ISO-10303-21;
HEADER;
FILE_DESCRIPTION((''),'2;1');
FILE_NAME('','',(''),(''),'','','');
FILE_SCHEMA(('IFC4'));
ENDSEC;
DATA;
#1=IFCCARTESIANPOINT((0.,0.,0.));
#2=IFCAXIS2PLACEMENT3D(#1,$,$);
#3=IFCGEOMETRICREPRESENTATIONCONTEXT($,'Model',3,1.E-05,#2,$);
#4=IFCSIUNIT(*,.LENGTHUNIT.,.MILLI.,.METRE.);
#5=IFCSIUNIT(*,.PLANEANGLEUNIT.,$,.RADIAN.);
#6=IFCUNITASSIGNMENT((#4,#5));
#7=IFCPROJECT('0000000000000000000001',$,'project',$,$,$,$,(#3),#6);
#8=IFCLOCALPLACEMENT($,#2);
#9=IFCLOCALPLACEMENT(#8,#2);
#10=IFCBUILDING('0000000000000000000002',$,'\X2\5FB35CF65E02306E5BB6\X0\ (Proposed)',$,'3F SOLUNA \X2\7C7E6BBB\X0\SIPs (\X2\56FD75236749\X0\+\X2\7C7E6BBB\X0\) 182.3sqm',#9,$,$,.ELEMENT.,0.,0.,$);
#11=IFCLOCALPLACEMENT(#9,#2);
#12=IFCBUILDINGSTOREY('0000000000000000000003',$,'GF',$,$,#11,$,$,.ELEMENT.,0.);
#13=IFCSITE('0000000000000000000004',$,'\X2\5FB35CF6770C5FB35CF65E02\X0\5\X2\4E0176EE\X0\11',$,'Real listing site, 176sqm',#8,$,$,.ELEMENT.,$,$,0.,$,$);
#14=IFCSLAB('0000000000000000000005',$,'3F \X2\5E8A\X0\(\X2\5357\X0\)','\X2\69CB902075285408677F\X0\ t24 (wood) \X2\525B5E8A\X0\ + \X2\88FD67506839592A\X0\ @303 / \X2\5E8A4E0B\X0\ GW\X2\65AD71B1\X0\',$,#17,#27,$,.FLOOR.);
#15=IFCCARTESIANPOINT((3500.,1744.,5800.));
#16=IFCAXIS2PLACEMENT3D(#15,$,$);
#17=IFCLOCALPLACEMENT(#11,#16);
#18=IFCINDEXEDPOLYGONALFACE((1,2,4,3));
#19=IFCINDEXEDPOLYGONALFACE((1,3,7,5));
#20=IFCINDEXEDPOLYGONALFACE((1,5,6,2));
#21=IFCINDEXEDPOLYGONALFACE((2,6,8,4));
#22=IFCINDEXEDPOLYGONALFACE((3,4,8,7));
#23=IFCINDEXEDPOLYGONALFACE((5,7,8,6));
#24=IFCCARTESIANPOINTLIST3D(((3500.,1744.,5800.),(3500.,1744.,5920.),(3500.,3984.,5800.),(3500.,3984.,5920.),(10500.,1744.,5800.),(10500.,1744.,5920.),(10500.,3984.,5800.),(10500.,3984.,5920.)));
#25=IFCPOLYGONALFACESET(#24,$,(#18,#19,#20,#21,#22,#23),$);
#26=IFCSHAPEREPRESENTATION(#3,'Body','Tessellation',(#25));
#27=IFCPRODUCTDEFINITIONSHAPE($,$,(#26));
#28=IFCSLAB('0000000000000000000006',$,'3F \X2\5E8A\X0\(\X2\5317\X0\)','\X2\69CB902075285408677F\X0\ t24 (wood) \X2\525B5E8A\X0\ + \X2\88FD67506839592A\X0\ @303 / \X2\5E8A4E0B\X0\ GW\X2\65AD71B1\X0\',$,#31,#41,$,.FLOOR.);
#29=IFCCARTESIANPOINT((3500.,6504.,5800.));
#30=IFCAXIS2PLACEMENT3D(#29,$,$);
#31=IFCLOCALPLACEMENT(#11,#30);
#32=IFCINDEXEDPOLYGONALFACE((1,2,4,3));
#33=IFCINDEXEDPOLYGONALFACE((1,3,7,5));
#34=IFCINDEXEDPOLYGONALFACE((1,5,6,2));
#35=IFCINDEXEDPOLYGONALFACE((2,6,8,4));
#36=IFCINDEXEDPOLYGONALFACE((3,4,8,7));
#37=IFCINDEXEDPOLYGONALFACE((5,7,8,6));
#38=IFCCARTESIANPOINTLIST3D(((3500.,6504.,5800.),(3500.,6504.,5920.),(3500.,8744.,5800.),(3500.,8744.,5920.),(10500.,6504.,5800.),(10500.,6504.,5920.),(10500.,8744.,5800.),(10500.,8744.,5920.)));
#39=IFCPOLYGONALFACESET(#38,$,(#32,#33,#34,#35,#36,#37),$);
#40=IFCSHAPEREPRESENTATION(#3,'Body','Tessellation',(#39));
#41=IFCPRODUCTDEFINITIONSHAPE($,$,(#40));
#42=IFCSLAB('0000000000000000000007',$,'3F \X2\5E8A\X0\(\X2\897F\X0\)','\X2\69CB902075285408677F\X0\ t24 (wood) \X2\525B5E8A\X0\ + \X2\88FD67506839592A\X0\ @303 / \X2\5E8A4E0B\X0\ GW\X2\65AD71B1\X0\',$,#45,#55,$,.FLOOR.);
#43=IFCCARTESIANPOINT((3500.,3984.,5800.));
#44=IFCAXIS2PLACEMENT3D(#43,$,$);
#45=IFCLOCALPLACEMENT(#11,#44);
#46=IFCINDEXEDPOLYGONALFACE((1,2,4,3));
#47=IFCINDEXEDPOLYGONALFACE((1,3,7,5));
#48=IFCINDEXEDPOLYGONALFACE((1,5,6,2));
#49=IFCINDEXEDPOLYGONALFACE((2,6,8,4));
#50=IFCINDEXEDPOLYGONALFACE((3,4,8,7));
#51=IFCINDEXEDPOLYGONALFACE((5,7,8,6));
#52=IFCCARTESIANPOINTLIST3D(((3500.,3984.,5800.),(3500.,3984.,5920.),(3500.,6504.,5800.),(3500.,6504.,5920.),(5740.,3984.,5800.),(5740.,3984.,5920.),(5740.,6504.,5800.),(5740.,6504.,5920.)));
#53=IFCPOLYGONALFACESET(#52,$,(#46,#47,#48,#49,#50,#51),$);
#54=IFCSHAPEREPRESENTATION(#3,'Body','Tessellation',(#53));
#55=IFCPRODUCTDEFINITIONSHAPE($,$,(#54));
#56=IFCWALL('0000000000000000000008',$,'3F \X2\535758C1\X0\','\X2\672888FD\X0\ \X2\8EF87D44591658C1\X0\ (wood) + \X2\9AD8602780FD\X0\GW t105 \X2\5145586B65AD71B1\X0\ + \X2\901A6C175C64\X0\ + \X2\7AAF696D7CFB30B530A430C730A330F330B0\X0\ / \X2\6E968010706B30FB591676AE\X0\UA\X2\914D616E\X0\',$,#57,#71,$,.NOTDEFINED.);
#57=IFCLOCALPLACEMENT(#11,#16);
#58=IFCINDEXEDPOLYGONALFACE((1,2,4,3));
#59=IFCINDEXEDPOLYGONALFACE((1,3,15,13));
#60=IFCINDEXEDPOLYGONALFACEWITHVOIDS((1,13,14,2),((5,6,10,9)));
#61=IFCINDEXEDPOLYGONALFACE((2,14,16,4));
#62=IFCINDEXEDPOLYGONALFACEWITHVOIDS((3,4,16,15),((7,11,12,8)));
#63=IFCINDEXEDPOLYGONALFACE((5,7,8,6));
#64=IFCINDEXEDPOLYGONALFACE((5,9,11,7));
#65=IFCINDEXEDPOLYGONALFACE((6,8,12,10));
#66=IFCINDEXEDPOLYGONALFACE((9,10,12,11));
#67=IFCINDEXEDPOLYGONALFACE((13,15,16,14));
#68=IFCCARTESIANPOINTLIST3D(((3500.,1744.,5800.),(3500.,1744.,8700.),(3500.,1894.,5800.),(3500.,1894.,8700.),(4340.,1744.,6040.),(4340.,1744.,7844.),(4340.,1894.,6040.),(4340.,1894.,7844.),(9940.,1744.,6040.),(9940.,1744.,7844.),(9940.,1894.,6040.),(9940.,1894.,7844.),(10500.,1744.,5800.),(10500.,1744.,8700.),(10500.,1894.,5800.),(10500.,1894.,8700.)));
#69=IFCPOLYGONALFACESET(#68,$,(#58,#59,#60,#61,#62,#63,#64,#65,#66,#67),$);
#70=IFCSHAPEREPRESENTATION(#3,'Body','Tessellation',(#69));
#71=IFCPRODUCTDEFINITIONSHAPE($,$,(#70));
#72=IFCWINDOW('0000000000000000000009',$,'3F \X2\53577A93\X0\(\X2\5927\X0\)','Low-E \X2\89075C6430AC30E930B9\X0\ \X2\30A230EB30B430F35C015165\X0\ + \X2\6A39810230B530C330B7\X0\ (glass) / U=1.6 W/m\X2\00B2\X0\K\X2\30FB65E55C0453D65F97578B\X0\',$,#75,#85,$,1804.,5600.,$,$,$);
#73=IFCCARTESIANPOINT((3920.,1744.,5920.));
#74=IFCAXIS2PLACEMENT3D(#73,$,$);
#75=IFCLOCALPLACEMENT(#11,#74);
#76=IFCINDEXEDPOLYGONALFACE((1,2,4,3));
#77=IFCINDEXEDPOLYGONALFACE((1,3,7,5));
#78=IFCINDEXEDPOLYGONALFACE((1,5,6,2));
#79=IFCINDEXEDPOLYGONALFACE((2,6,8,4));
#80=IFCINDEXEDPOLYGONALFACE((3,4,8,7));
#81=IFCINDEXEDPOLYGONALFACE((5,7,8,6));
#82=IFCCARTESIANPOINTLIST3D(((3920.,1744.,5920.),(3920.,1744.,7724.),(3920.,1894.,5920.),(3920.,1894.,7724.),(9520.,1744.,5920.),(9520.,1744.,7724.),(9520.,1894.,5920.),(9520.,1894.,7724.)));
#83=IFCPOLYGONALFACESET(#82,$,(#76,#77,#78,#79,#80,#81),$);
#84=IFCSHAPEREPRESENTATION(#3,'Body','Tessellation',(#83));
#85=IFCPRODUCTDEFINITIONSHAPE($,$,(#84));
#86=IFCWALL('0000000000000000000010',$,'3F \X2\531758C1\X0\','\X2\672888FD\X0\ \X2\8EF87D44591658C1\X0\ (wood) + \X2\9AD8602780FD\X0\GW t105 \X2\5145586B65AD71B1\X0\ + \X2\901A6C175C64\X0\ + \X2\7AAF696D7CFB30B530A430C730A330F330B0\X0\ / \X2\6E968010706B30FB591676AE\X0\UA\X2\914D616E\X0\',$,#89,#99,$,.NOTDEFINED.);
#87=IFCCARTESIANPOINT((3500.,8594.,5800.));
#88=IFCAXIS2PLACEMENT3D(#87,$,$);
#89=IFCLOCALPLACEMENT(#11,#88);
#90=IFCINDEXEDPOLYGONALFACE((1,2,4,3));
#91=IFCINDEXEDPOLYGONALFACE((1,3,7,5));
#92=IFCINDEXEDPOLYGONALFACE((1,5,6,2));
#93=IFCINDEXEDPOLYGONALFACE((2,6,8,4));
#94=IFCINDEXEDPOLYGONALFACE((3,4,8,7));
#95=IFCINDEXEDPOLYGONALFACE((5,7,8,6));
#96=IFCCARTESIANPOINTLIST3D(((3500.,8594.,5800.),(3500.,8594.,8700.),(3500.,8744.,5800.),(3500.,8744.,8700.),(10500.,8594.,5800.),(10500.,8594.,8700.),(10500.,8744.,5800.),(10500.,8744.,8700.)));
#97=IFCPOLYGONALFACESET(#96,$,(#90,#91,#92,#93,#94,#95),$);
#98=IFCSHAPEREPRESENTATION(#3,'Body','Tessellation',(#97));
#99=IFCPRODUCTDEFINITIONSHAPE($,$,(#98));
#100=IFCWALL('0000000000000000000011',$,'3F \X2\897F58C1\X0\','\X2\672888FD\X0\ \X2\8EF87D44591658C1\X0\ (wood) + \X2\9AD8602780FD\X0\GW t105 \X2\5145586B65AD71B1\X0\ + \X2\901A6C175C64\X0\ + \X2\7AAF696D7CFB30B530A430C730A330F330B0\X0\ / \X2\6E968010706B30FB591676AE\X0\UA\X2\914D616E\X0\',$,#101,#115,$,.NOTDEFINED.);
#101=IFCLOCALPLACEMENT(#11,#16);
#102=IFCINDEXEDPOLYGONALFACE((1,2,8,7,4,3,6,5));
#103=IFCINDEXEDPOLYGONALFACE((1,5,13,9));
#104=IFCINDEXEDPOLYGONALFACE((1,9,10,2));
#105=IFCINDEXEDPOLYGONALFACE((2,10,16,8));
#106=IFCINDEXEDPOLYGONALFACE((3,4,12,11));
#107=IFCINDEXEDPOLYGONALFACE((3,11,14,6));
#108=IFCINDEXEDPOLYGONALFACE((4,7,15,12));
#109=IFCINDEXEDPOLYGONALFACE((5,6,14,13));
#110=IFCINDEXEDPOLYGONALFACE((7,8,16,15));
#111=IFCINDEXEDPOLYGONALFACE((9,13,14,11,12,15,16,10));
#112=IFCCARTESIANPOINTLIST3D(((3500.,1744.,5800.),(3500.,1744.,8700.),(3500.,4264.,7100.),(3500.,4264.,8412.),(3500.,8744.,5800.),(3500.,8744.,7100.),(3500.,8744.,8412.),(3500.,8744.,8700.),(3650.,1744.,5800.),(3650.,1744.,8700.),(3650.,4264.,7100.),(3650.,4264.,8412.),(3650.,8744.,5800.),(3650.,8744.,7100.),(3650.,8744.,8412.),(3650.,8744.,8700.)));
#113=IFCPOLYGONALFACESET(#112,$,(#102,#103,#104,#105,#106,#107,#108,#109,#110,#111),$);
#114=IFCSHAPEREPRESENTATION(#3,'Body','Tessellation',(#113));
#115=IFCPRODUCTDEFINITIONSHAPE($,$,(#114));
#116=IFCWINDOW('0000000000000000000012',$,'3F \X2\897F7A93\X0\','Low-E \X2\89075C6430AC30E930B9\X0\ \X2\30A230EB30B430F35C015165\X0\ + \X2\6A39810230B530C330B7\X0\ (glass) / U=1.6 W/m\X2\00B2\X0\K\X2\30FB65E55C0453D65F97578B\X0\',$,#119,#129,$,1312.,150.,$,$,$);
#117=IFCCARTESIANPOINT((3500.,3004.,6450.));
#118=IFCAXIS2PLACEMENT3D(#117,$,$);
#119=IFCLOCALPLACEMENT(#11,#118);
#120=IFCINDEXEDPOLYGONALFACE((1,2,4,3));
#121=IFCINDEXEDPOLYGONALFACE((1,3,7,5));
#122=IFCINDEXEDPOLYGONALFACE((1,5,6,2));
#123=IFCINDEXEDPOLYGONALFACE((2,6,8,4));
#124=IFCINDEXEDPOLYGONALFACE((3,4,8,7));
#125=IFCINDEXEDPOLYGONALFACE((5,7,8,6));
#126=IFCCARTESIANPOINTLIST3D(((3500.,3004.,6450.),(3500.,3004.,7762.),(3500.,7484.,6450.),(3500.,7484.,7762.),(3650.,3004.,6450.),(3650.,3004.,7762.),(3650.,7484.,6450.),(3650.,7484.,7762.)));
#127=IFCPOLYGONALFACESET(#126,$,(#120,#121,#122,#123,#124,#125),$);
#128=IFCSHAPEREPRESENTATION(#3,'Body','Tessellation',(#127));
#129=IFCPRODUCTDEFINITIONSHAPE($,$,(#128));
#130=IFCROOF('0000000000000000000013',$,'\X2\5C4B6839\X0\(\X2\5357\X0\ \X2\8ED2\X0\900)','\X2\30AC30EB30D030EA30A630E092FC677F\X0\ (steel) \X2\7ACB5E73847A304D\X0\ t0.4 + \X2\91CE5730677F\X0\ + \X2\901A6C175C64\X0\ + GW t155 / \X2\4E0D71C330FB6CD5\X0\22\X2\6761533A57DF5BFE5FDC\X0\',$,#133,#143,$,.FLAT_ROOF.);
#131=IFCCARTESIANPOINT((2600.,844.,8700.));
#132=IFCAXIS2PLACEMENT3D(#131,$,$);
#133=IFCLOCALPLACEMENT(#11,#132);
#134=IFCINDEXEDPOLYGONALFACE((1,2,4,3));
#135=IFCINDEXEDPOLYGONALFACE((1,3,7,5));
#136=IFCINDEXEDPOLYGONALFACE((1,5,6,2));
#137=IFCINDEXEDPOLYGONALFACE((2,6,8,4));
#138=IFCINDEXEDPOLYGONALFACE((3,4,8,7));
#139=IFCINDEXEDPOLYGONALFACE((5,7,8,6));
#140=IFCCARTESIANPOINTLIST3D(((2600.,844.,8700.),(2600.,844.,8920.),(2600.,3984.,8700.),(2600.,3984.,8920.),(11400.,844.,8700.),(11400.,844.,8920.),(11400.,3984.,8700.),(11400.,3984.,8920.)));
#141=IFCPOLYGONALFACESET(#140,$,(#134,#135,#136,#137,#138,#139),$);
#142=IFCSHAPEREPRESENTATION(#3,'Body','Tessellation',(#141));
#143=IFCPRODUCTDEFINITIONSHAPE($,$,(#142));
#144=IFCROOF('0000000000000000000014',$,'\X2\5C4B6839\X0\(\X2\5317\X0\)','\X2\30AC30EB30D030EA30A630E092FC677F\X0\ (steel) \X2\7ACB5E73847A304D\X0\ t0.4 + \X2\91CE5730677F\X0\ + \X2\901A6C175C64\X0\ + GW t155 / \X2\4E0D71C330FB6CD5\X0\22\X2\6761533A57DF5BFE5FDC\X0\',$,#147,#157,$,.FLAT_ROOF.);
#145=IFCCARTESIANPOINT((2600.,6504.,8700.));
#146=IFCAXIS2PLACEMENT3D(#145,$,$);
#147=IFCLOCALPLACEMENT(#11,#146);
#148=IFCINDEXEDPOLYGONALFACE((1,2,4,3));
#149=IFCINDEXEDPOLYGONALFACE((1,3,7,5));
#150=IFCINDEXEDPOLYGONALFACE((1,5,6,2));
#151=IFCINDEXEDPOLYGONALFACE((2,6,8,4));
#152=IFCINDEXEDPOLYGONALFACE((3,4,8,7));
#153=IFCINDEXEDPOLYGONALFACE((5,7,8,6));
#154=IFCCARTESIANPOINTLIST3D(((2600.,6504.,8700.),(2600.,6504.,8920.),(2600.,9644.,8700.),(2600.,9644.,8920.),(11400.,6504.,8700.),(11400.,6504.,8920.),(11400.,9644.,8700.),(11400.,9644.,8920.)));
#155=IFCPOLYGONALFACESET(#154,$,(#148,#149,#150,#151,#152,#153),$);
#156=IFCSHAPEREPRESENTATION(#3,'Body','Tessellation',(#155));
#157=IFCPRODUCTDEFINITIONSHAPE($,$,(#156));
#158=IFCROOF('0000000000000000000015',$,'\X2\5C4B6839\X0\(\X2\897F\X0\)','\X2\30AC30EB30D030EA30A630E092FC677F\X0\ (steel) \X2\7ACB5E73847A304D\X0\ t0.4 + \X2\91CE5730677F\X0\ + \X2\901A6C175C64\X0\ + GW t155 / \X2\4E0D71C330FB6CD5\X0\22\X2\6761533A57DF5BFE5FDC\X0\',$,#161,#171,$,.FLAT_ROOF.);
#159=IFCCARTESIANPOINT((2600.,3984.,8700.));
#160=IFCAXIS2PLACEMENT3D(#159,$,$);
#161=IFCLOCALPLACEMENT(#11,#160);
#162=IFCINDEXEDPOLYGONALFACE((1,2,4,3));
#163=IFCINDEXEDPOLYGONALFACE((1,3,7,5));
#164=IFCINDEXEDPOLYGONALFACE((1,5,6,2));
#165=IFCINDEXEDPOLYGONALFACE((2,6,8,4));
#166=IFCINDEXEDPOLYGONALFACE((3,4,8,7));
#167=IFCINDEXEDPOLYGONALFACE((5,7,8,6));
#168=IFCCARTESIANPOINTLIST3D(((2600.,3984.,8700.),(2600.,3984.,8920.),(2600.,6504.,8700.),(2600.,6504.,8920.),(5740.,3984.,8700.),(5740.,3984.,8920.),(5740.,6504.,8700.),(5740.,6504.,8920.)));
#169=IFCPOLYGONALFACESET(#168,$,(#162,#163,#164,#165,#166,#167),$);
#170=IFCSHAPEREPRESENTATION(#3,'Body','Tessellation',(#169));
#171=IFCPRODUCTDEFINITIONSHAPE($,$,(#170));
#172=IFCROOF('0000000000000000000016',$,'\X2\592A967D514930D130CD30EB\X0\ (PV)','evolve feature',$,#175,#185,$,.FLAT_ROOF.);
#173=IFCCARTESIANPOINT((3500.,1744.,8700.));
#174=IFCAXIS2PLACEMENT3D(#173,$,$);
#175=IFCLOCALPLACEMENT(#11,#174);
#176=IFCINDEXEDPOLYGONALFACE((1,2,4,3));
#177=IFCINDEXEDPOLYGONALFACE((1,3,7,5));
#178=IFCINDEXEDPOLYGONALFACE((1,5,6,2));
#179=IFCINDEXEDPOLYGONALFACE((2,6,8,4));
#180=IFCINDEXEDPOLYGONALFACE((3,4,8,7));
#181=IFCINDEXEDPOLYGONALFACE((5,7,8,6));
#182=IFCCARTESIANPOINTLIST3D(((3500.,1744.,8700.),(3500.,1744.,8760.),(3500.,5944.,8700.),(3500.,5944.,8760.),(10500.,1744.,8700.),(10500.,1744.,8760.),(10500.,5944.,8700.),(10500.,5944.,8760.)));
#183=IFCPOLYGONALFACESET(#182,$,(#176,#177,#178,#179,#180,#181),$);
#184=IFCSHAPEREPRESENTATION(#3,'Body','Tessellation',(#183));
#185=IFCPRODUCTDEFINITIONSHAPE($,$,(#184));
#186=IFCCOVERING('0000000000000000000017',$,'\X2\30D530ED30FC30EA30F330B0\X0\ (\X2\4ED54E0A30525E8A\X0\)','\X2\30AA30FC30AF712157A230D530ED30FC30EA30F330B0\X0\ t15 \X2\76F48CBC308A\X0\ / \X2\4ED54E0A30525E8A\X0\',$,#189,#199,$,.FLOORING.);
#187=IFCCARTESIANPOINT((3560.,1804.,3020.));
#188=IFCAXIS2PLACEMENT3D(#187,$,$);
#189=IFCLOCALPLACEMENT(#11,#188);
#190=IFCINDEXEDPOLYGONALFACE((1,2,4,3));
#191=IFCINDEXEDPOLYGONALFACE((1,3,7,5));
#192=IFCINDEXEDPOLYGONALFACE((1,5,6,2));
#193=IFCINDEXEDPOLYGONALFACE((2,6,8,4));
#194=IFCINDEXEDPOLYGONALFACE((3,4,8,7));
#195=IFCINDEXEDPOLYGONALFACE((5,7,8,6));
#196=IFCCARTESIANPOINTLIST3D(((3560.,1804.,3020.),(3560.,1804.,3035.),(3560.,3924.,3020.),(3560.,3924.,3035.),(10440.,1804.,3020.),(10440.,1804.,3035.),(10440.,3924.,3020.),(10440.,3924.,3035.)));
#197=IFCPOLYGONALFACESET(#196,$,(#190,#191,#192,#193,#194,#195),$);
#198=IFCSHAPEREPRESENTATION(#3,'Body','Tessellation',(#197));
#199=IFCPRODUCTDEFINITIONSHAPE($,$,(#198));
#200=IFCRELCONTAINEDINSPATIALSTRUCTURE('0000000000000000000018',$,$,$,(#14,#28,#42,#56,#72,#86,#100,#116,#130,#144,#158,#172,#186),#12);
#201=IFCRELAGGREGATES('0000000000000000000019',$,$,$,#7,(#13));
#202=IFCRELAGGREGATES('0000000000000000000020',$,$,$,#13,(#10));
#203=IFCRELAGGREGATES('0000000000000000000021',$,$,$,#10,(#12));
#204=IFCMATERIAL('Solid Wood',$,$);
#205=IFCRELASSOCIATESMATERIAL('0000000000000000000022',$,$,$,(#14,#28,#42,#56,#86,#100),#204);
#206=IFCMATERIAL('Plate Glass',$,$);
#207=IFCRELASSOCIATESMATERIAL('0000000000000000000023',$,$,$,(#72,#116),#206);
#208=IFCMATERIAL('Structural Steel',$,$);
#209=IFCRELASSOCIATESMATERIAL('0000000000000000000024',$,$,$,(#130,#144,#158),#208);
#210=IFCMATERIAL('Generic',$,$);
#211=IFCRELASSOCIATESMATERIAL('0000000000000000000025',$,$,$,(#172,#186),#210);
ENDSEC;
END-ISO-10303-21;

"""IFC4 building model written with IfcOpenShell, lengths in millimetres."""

from ifc_helpers import new_model, si_unit, frame, frame_2d, origin, place, context, project, spatial, rectangle, extrude, material, element, fill, save


model = new_model("IFC4")

# Units and contexts
model_context = context("Model", 3, precision=1e-05, world=origin())
ifc_project = project(units=[si_unit("LENGTHUNIT", "METRE", prefix="MILLI"), si_unit("PLANEANGLEUNIT", "RADIAN")], contexts=[model_context])

# Site, building, storey
site_placement = place(None, origin())
site = spatial("IfcSite", under=ifc_project, at=site_placement, Name="徳島県徳島市5丁目11", ObjectType="Real listing site, 176sqm", CompositionType="ELEMENT", RefElevation=0.0)
building_placement = place(site_placement, origin())
building = spatial("IfcBuilding", under=site, at=building_placement, Name="徳島市の家 (Proposed)", ObjectType="3F SOLUNA 籾殻SIPs (国産杉+籾殻) 182.3sqm", CompositionType="ELEMENT", ElevationOfRefHeight=0.0, ElevationOfTerrain=0.0)
storey_placement = place(building_placement, origin())
storey = spatial("IfcBuildingStorey", under=building, at=storey_placement, Name="GF", CompositionType="ELEMENT", Elevation=0.0)

# Slabs
ifc_material_1 = material(Name="Solid Wood")
slab_1_placement = place(storey_placement, frame((3500.0, 1744.0, 5800.0)))
element("IfcSlab", 1, at=slab_1_placement, inside=storey, material=ifc_material_1, Name="3F 床(南)", Description="構造用合板 t24 (wood) 剛床 + 製材根太 @303 / 床下 GW断熱", PredefinedType="FLOOR", context=model_context, shape_type="SweptSolid", body=[
    extrude(rectangle(XDim=7000.0, YDim=2240.0, at=frame_2d((3500.0, 1120.0))), frame((3500.0, 1744.0, 5800.0)), (0.0, 0.0, 1.0), 120.0),
])
slab_2_placement = place(storey_placement, frame((3500.0, 6504.0, 5800.0)))
element("IfcSlab", 2, at=slab_2_placement, inside=storey, material=ifc_material_1, Name="3F 床(北)", Description="構造用合板 t24 (wood) 剛床 + 製材根太 @303 / 床下 GW断熱", PredefinedType="FLOOR", context=model_context, shape_type="SweptSolid", body=[
    extrude(rectangle(XDim=7000.0, YDim=2240.0, at=frame_2d((3500.0, 1120.0))), frame((3500.0, 6504.0, 5800.0)), (0.0, 0.0, 1.0), 120.0),
])
slab_3_placement = place(storey_placement, frame((3500.0, 3984.0, 5800.0)))
element("IfcSlab", 3, at=slab_3_placement, inside=storey, material=ifc_material_1, Name="3F 床(西)", Description="構造用合板 t24 (wood) 剛床 + 製材根太 @303 / 床下 GW断熱", PredefinedType="FLOOR", context=model_context, shape_type="SweptSolid", body=[
    extrude(rectangle(XDim=2240.0, YDim=2520.0, at=frame_2d((1120.0, 1260.0))), frame((3500.0, 3984.0, 5800.0)), (0.0, 0.0, 1.0), 120.0),
])

# Wall, opening, window
wall_1_placement = place(storey_placement, frame((3500.0, 1744.0, 5800.0)))
wall_1 = element("IfcWall", 4, at=wall_1_placement, inside=storey, material=ifc_material_1, Name="3F 南壁", Description="木製 軸組外壁 (wood) + 高性能GW t105 充填断熱 + 通気層 + 窯業系サイディング / 準耐火・外皮UA配慮", PredefinedType="NOTDEFINED", context=model_context, shape_type="SweptSolid", body=[
    extrude(rectangle(XDim=7000.0, YDim=150.0, at=frame_2d((3500.0, 75.0))), frame((3500.0, 1744.0, 5800.0)), (0.0, 0.0, 1.0), 2900.0),
])
opening_1_placement = place(storey_placement, frame((3920.0, 1744.0, 5920.0)))
opening_1 = element("IfcOpeningElement", 5, at=opening_1_placement, cuts=wall_1, PredefinedType="NOTDEFINED", context=model_context, shape_type="SweptSolid", body=[
    extrude(rectangle(XDim=5600.0, YDim=150.0, at=frame_2d((2800.0, 75.0))), frame((3920.0, 1744.0, 5920.0)), (0.0, 0.0, 1.0), 1804.0),
])
ifc_material_2 = material(Name="Plate Glass")
window_1_placement = place(storey_placement, frame((3920.0, 1744.0, 5920.0)))
window_1 = element("IfcWindow", 6, at=window_1_placement, inside=storey, material=ifc_material_2, Name="3F 南窓(大)", Description="Low-E 複層ガラス アルゴン封入 + 樹脂サッシ (glass) / U=1.6 W/m²K・日射取得型", OverallHeight=1804.0, OverallWidth=5600.0, context=model_context, shape_type="SweptSolid", body=[
    extrude(rectangle(XDim=5600.0, YDim=150.0, at=frame_2d((2800.0, 75.0))), frame((3920.0, 1744.0, 5920.0)), (0.0, 0.0, 1.0), 1804.0),
])
fill(opening_1, window_1)

# Wall
wall_2_placement = place(storey_placement, frame((3500.0, 8594.0, 5800.0)))
element("IfcWall", 7, at=wall_2_placement, inside=storey, material=ifc_material_1, Name="3F 北壁", Description="木製 軸組外壁 (wood) + 高性能GW t105 充填断熱 + 通気層 + 窯業系サイディング / 準耐火・外皮UA配慮", PredefinedType="NOTDEFINED", context=model_context, shape_type="SweptSolid", body=[
    extrude(rectangle(XDim=7000.0, YDim=150.0, at=frame_2d((3500.0, 75.0))), frame((3500.0, 8594.0, 5800.0)), (0.0, 0.0, 1.0), 2900.0),
])

# Wall, opening, window
wall_3_placement = place(storey_placement, frame((3500.0, 1744.0, 5800.0)))
wall_3 = element("IfcWall", 8, at=wall_3_placement, inside=storey, material=ifc_material_1, Name="3F 西壁", Description="木製 軸組外壁 (wood) + 高性能GW t105 充填断熱 + 通気層 + 窯業系サイディング / 準耐火・外皮UA配慮", PredefinedType="NOTDEFINED", context=model_context, shape_type="SweptSolid", body=[
    extrude(rectangle(XDim=150.0, YDim=7000.0, at=frame_2d((75.0, 3500.0))), frame((3500.0, 1744.0, 5800.0)), (0.0, 0.0, 1.0), 2900.0),
])
opening_2_placement = place(storey_placement, frame((3500.0, 3004.0, 6450.0)))
opening_2 = element("IfcOpeningElement", 9, at=opening_2_placement, cuts=wall_3, PredefinedType="NOTDEFINED", context=model_context, shape_type="SweptSolid", body=[
    extrude(rectangle(XDim=150.0, YDim=4480.0, at=frame_2d((75.0, 2240.0))), frame((3500.0, 3004.0, 6450.0)), (0.0, 0.0, 1.0), 1312.0),
])
window_2_placement = place(storey_placement, frame((3500.0, 3004.0, 6450.0)))
window_2 = element("IfcWindow", 10, at=window_2_placement, inside=storey, material=ifc_material_2, Name="3F 西窓", Description="Low-E 複層ガラス アルゴン封入 + 樹脂サッシ (glass) / U=1.6 W/m²K・日射取得型", OverallHeight=1312.0, OverallWidth=150.0, context=model_context, shape_type="SweptSolid", body=[
    extrude(rectangle(XDim=150.0, YDim=4480.0, at=frame_2d((75.0, 2240.0))), frame((3500.0, 3004.0, 6450.0)), (0.0, 0.0, 1.0), 1312.0),
])
fill(opening_2, window_2)

# Roofs
ifc_material_3 = material(Name="Structural Steel")
roof_1_placement = place(storey_placement, frame((2600.0, 844.0, 8700.0)))
element("IfcRoof", 11, at=roof_1_placement, inside=storey, material=ifc_material_3, Name="屋根(南 軒900)", Description="ガルバリウム鋼板 (steel) 立平葺き t0.4 + 野地板 + 通気層 + GW t155 / 不燃・法22条区域対応", PredefinedType="FLAT_ROOF", context=model_context, shape_type="SweptSolid", body=[
    extrude(rectangle(XDim=8800.0, YDim=3140.0, at=frame_2d((4400.0, 1570.0))), frame((2600.0, 844.0, 8700.0)), (0.0, 0.0, 1.0), 220.0),
])
roof_2_placement = place(storey_placement, frame((2600.0, 6504.0, 8700.0)))
element("IfcRoof", 12, at=roof_2_placement, inside=storey, material=ifc_material_3, Name="屋根(北)", Description="ガルバリウム鋼板 (steel) 立平葺き t0.4 + 野地板 + 通気層 + GW t155 / 不燃・法22条区域対応", PredefinedType="FLAT_ROOF", context=model_context, shape_type="SweptSolid", body=[
    extrude(rectangle(XDim=8800.0, YDim=3140.0, at=frame_2d((4400.0, 1570.0))), frame((2600.0, 6504.0, 8700.0)), (0.0, 0.0, 1.0), 220.0),
])
roof_3_placement = place(storey_placement, frame((2600.0, 3984.0, 8700.0)))
element("IfcRoof", 13, at=roof_3_placement, inside=storey, material=ifc_material_3, Name="屋根(西)", Description="ガルバリウム鋼板 (steel) 立平葺き t0.4 + 野地板 + 通気層 + GW t155 / 不燃・法22条区域対応", PredefinedType="FLAT_ROOF", context=model_context, shape_type="SweptSolid", body=[
    extrude(rectangle(XDim=3140.0, YDim=2520.0, at=frame_2d((1570.0, 1260.0))), frame((2600.0, 3984.0, 8700.0)), (0.0, 0.0, 1.0), 220.0),
])
ifc_material_4 = material(Name="Generic")
roof_4_placement = place(storey_placement, frame((3500.0, 1744.0, 8700.0)))
element("IfcRoof", 14, at=roof_4_placement, inside=storey, material=ifc_material_4, Name="太陽光パネル (PV)", Description="evolve feature", PredefinedType="FLAT_ROOF", context=model_context, shape_type="SweptSolid", body=[
    extrude(rectangle(XDim=7000.0, YDim=4200.0, at=frame_2d((3500.0, 2100.0))), frame((3500.0, 1744.0, 8700.0)), (0.0, 0.0, 1.0), 60.0),
])

# Covering
covering_1_placement = place(storey_placement, frame((3560.0, 1804.0, 3020.0)))
element("IfcCovering", 15, at=covering_1_placement, inside=storey, material=ifc_material_4, Name="フローリング (仕上げ床)", Description="オーク無垢フローリング t15 直貼り / 仕上げ床", PredefinedType="FLOORING", context=model_context, shape_type="SweptSolid", body=[
    extrude(rectangle(XDim=6880.0, YDim=2120.0, at=frame_2d((3440.0, 1060.0))), frame((3560.0, 1804.0, 3020.0)), (0.0, 0.0, 1.0), 15.0),
])

save(model, "model.ifc")
